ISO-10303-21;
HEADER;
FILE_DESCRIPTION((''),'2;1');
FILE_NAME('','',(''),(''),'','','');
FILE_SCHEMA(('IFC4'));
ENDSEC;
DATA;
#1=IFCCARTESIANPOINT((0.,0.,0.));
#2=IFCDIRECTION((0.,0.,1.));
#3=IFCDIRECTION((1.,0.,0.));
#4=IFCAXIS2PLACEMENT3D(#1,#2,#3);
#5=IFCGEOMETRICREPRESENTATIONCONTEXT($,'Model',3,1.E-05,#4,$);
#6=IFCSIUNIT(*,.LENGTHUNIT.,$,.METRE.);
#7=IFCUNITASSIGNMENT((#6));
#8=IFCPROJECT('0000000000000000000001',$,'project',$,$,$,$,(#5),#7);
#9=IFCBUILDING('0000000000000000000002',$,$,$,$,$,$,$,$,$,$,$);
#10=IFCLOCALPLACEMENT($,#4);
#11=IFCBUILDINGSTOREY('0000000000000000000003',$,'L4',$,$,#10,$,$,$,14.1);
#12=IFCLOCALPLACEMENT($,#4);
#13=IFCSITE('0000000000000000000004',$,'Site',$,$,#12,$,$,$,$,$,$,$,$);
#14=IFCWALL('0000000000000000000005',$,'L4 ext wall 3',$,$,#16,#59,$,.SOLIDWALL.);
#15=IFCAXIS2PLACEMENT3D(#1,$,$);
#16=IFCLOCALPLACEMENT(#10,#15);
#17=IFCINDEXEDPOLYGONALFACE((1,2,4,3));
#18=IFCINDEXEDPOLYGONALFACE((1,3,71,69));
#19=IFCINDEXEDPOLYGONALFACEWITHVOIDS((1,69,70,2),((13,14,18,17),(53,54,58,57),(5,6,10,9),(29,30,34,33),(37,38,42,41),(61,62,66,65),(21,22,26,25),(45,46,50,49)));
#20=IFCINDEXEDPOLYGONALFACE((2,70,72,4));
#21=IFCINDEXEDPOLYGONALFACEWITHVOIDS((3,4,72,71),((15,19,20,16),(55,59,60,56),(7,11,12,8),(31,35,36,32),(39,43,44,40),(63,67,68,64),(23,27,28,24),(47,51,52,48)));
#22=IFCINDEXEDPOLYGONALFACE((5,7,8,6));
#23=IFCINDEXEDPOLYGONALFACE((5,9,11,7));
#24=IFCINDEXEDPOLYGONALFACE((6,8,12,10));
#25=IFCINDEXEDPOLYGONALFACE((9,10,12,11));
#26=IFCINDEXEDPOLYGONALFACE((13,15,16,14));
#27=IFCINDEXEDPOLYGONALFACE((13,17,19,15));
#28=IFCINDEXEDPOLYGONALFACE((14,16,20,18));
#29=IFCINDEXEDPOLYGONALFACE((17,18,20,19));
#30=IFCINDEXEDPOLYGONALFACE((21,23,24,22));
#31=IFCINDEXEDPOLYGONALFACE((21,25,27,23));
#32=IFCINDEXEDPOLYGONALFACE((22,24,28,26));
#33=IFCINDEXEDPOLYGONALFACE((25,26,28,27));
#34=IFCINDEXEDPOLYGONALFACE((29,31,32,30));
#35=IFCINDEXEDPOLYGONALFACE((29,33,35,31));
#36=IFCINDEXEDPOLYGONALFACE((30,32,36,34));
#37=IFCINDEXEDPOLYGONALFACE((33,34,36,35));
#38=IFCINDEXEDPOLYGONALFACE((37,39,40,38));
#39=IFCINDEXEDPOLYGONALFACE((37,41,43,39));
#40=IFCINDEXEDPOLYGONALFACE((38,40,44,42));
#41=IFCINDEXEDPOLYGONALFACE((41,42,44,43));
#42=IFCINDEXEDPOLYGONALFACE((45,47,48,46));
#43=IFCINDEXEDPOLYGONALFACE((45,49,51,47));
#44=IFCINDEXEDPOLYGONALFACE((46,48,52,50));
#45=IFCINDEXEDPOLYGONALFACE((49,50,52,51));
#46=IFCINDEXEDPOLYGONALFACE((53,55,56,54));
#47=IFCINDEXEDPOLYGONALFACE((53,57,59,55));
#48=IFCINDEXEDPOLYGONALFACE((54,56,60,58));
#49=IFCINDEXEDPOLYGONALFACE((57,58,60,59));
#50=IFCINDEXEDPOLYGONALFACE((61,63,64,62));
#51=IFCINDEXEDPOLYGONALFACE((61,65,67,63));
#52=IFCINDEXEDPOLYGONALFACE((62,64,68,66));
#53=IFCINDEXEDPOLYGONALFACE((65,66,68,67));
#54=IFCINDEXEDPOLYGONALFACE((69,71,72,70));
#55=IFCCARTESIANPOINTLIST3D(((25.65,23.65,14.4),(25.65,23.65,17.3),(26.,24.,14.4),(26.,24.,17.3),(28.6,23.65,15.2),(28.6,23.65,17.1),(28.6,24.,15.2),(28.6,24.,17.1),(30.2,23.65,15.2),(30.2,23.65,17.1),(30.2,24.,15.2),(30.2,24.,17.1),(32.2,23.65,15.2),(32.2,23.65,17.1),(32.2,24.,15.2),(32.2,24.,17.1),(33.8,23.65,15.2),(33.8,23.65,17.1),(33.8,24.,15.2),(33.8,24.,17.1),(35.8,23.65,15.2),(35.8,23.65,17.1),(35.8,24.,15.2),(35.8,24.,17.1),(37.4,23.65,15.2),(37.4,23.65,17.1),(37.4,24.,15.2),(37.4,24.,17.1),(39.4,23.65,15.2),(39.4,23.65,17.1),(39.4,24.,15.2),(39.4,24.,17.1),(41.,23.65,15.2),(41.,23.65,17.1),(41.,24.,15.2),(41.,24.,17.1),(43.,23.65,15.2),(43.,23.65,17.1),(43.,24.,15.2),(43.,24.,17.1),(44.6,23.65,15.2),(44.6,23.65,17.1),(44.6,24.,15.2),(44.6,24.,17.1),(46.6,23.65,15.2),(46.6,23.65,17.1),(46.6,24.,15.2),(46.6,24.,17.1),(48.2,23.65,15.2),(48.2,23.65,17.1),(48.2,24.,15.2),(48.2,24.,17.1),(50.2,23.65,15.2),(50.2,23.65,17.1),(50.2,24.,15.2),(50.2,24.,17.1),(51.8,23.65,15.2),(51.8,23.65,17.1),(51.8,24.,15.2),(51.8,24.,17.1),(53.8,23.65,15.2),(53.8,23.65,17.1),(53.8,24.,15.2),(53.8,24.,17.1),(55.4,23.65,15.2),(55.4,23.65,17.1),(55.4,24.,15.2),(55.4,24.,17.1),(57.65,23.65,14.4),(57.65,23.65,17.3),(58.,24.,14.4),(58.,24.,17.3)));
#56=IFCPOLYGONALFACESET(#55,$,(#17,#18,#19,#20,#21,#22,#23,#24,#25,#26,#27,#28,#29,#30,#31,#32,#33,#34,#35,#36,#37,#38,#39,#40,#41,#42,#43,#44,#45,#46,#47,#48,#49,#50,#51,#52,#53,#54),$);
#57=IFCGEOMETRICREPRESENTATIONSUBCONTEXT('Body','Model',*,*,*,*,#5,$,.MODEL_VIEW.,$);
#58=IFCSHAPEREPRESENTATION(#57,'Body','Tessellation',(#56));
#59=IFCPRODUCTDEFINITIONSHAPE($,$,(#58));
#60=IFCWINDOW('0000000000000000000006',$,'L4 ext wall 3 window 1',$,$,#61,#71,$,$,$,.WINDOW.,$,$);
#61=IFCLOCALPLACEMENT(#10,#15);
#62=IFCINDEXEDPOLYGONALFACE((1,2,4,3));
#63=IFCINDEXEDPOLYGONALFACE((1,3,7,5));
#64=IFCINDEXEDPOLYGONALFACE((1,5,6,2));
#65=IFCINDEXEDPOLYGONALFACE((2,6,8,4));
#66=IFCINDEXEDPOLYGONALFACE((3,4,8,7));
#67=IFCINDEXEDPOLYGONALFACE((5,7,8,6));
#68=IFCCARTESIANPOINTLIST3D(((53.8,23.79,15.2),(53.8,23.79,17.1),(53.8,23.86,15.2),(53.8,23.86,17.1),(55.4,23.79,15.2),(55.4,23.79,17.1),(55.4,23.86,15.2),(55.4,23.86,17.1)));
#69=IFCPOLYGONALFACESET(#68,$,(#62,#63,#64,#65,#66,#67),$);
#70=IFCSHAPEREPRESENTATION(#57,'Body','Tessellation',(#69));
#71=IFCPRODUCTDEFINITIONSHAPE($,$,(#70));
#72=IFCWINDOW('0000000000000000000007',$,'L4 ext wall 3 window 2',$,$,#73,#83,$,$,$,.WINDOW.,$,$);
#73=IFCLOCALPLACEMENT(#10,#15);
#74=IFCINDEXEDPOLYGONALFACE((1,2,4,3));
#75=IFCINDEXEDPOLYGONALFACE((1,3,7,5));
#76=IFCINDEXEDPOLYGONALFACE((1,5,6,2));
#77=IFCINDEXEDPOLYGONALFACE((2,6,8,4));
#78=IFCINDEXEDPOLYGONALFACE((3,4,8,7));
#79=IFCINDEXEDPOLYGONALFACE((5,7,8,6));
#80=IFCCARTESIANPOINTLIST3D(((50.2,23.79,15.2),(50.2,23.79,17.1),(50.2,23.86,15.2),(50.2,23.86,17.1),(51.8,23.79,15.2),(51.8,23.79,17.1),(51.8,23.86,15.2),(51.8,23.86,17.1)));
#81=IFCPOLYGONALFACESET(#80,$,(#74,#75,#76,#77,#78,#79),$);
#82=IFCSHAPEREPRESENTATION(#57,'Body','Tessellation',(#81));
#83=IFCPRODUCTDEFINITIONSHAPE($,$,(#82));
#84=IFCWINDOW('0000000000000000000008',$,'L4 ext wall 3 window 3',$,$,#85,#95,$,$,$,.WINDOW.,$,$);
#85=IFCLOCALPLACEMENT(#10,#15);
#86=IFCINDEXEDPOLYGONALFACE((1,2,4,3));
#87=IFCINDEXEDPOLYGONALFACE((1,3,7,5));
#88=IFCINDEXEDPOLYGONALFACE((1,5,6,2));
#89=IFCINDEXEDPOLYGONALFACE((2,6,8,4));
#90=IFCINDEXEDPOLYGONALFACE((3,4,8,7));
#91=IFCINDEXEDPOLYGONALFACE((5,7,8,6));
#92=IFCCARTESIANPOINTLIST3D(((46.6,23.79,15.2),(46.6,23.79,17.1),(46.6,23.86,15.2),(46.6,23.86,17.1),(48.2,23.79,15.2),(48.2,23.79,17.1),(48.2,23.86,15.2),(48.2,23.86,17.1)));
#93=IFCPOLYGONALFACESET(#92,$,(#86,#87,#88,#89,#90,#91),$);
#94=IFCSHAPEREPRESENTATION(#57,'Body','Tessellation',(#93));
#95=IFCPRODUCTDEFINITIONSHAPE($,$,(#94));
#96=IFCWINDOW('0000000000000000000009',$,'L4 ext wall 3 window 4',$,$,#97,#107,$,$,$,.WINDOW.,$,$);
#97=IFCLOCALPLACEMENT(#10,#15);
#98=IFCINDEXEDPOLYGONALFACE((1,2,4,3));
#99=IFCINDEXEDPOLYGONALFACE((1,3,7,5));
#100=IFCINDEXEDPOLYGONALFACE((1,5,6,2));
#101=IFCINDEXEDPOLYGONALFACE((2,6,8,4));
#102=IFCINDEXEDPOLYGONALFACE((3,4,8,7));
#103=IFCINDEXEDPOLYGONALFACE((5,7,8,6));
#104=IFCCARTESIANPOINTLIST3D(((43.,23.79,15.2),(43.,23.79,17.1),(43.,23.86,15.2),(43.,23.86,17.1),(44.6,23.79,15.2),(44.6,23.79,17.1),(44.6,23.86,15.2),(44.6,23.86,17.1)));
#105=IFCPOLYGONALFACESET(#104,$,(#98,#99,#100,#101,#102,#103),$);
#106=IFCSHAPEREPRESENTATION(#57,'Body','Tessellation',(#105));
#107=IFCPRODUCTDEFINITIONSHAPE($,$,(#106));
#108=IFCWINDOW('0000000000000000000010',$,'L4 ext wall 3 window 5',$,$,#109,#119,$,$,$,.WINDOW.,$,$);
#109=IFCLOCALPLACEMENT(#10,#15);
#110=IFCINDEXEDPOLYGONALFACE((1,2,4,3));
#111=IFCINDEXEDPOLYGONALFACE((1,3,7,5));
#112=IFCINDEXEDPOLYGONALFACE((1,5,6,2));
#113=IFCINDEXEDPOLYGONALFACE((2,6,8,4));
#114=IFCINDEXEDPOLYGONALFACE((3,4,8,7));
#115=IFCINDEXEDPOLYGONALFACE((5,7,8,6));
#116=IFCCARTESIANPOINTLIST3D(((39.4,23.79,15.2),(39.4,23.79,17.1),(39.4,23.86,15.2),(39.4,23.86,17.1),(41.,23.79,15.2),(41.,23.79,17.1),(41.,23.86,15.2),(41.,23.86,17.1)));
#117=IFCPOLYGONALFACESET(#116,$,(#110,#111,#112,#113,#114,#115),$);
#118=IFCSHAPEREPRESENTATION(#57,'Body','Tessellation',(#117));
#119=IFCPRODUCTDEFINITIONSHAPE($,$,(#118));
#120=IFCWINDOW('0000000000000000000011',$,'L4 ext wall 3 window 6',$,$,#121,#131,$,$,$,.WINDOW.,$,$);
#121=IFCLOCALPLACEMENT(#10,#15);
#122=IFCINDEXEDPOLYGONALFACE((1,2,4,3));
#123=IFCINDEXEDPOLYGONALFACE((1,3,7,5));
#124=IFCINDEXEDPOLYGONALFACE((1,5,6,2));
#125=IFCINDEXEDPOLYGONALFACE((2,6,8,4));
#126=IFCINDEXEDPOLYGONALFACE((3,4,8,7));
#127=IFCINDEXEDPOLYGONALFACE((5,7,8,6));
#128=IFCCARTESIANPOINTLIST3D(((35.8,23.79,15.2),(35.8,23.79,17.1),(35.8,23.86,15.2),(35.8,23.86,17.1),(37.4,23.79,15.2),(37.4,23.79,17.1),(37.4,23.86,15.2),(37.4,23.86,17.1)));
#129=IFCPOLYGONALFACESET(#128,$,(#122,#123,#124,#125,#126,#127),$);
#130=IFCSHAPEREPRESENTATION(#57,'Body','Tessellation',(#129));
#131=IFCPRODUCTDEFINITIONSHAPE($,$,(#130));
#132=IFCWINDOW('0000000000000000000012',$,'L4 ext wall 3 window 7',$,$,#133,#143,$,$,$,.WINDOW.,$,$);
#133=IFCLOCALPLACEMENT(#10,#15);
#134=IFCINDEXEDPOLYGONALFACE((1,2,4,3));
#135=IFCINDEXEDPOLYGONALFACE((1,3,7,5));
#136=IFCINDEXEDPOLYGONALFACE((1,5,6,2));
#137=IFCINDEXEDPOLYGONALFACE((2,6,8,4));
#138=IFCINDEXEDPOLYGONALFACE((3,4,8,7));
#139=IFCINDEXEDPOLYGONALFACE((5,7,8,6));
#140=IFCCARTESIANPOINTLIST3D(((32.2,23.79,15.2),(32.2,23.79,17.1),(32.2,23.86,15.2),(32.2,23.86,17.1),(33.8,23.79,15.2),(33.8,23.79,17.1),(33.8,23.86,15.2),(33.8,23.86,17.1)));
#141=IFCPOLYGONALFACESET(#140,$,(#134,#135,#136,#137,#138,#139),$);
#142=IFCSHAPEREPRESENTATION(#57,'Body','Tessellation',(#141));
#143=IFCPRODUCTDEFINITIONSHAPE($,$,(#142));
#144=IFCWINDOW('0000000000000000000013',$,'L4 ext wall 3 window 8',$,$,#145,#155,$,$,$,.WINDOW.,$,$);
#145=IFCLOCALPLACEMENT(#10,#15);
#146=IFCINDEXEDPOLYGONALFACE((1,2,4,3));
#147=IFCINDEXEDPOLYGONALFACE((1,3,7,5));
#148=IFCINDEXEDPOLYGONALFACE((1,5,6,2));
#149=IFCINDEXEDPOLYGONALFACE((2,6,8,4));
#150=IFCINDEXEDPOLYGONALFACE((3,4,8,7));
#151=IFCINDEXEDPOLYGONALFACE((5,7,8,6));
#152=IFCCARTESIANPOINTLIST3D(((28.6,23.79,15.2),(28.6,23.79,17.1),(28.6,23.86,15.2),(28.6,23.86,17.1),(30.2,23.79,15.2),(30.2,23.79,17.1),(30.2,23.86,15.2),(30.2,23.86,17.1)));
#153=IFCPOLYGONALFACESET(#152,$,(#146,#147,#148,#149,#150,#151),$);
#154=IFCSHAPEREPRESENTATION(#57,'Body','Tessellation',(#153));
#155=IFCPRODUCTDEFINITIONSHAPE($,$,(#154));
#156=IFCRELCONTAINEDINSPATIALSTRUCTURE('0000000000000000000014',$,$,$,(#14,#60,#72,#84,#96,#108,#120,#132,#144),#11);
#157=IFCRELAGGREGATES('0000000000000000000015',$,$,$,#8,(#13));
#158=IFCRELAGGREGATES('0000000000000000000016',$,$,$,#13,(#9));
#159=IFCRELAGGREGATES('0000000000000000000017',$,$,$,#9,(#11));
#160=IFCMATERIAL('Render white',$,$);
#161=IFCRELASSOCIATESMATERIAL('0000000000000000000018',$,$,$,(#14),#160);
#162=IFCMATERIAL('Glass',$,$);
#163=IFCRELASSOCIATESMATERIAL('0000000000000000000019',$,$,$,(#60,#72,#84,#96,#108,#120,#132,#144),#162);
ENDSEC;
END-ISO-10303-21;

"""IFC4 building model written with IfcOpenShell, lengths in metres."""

from ifc_helpers import new_model, si_unit, frame, origin_with_axes, place, context, subcontext, project, spatial, polyline, outline, extrude, material, element, fill, save


model = new_model("IFC4")

# Units and contexts
model_context = context("Model", 3, precision=1e-05, world=origin_with_axes())
body_context = subcontext(model_context, "Body", "Model", "MODEL_VIEW")
ifc_project = project(units=[si_unit("LENGTHUNIT", "METRE")], contexts=[model_context])

# Site, building, storey
site_placement = place(None, origin_with_axes())
site = spatial("IfcSite", under=ifc_project, at=site_placement, Name="Site")
building = spatial("IfcBuilding", under=site)
storey_placement = place(None, origin_with_axes())
storey = spatial("IfcBuildingStorey", under=building, at=storey_placement, Name="L4", Elevation=14.1)

# Wall, openings, windows
ifc_material_1 = material(Name="Render white")
wall_1_placement = place(storey_placement, origin_with_axes())
wall_1 = element("IfcWall", 1, at=wall_1_placement, inside=storey, material=ifc_material_1, Name="L4 ext wall 3", PredefinedType="SOLIDWALL", context=body_context, shape_type="SweptSolid", body=[
    extrude(outline(polyline([(58.0, 24.0), (26.0, 24.0), (25.65, 23.65), (57.65, 23.65), (58.0, 24.0)])), frame((0.0, 0.0, 14.4), z_axis=(0.0, 0.0, 1.0), x_axis=(1.0, 0.0, 0.0)), (0.0, 0.0, 1.0), 2.9),
])
opening_1_placement = place(wall_1_placement, origin_with_axes())
opening_1 = element("IfcOpeningElement", 2, at=opening_1_placement, cuts=wall_1, context=body_context, shape_type="SweptSolid", body=[
    extrude(outline(polyline([(55.4, 24.05), (53.8, 24.05), (53.8, 23.6), (55.4, 23.6), (55.4, 24.05)])), frame((0.0, 0.0, 15.2), z_axis=(0.0, 0.0, 1.0), x_axis=(1.0, 0.0, 0.0)), (0.0, 0.0, 1.0), 1.9),
])
opening_2_placement = place(wall_1_placement, origin_with_axes())
opening_2 = element("IfcOpeningElement", 3, at=opening_2_placement, cuts=wall_1, context=body_context, shape_type="SweptSolid", body=[
    extrude(outline(polyline([(51.8, 24.05), (50.2, 24.05), (50.2, 23.6), (51.8, 23.6), (51.8, 24.05)])), frame((0.0, 0.0, 15.2), z_axis=(0.0, 0.0, 1.0), x_axis=(1.0, 0.0, 0.0)), (0.0, 0.0, 1.0), 1.9),
])
opening_3_placement = place(wall_1_placement, origin_with_axes())
opening_3 = element("IfcOpeningElement", 4, at=opening_3_placement, cuts=wall_1, context=body_context, shape_type="SweptSolid", body=[
    extrude(outline(polyline([(48.2, 24.05), (46.6, 24.05), (46.6, 23.6), (48.2, 23.6), (48.2, 24.05)])), frame((0.0, 0.0, 15.2), z_axis=(0.0, 0.0, 1.0), x_axis=(1.0, 0.0, 0.0)), (0.0, 0.0, 1.0), 1.9),
])
opening_4_placement = place(wall_1_placement, origin_with_axes())
opening_4 = element("IfcOpeningElement", 5, at=opening_4_placement, cuts=wall_1, context=body_context, shape_type="SweptSolid", body=[
    extrude(outline(polyline([(44.6, 24.05), (43.0, 24.05), (43.0, 23.6), (44.6, 23.6), (44.6, 24.05)])), frame((0.0, 0.0, 15.2), z_axis=(0.0, 0.0, 1.0), x_axis=(1.0, 0.0, 0.0)), (0.0, 0.0, 1.0), 1.9),
])
opening_5_placement = place(wall_1_placement, origin_with_axes())
opening_5 = element("IfcOpeningElement", 6, at=opening_5_placement, cuts=wall_1, context=body_context, shape_type="SweptSolid", body=[
    extrude(outline(polyline([(41.0, 24.05), (39.4, 24.05), (39.4, 23.6), (41.0, 23.6), (41.0, 24.05)])), frame((0.0, 0.0, 15.2), z_axis=(0.0, 0.0, 1.0), x_axis=(1.0, 0.0, 0.0)), (0.0, 0.0, 1.0), 1.9),
])
opening_6_placement = place(wall_1_placement, origin_with_axes())
opening_6 = element("IfcOpeningElement", 7, at=opening_6_placement, cuts=wall_1, context=body_context, shape_type="SweptSolid", body=[
    extrude(outline(polyline([(37.4, 24.05), (35.8, 24.05), (35.8, 23.6), (37.4, 23.6), (37.4, 24.05)])), frame((0.0, 0.0, 15.2), z_axis=(0.0, 0.0, 1.0), x_axis=(1.0, 0.0, 0.0)), (0.0, 0.0, 1.0), 1.9),
])
opening_7_placement = place(wall_1_placement, origin_with_axes())
opening_7 = element("IfcOpeningElement", 8, at=opening_7_placement, cuts=wall_1, context=body_context, shape_type="SweptSolid", body=[
    extrude(outline(polyline([(33.8, 24.05), (32.2, 24.05), (32.2, 23.6), (33.8, 23.6), (33.8, 24.05)])), frame((0.0, 0.0, 15.2), z_axis=(0.0, 0.0, 1.0), x_axis=(1.0, 0.0, 0.0)), (0.0, 0.0, 1.0), 1.9),
])
opening_8_placement = place(wall_1_placement, origin_with_axes())
opening_8 = element("IfcOpeningElement", 9, at=opening_8_placement, cuts=wall_1, context=body_context, shape_type="SweptSolid", body=[
    extrude(outline(polyline([(30.2, 24.05), (28.6, 24.05), (28.6, 23.6), (30.2, 23.6), (30.2, 24.05)])), frame((0.0, 0.0, 15.2), z_axis=(0.0, 0.0, 1.0), x_axis=(1.0, 0.0, 0.0)), (0.0, 0.0, 1.0), 1.9),
])
ifc_material_2 = material(Name="Glass")
window_1_placement = place(storey_placement, origin_with_axes())
window_1 = element("IfcWindow", 10, at=window_1_placement, inside=storey, material=ifc_material_2, Name="L4 ext wall 3 window 1", PredefinedType="WINDOW", context=body_context, shape_type="SweptSolid", body=[
    extrude(outline(polyline([(55.4, 23.86), (53.8, 23.86), (53.8, 23.79), (55.4, 23.79), (55.4, 23.86)])), frame((0.0, 0.0, 15.2), z_axis=(0.0, 0.0, 1.0), x_axis=(1.0, 0.0, 0.0)), (0.0, 0.0, 1.0), 1.9),
])
fill(opening_1, window_1)
window_2_placement = place(storey_placement, origin_with_axes())
window_2 = element("IfcWindow", 11, at=window_2_placement, inside=storey, material=ifc_material_2, Name="L4 ext wall 3 window 2", PredefinedType="WINDOW", context=body_context, shape_type="SweptSolid", body=[
    extrude(outline(polyline([(51.8, 23.86), (50.2, 23.86), (50.2, 23.79), (51.8, 23.79), (51.8, 23.86)])), frame((0.0, 0.0, 15.2), z_axis=(0.0, 0.0, 1.0), x_axis=(1.0, 0.0, 0.0)), (0.0, 0.0, 1.0), 1.9),
])
fill(opening_2, window_2)
window_3_placement = place(storey_placement, origin_with_axes())
window_3 = element("IfcWindow", 12, at=window_3_placement, inside=storey, material=ifc_material_2, Name="L4 ext wall 3 window 3", PredefinedType="WINDOW", context=body_context, shape_type="SweptSolid", body=[
    extrude(outline(polyline([(48.2, 23.86), (46.6, 23.86), (46.6, 23.79), (48.2, 23.79), (48.2, 23.86)])), frame((0.0, 0.0, 15.2), z_axis=(0.0, 0.0, 1.0), x_axis=(1.0, 0.0, 0.0)), (0.0, 0.0, 1.0), 1.9),
])
fill(opening_3, window_3)
window_4_placement = place(storey_placement, origin_with_axes())
window_4 = element("IfcWindow", 13, at=window_4_placement, inside=storey, material=ifc_material_2, Name="L4 ext wall 3 window 4", PredefinedType="WINDOW", context=body_context, shape_type="SweptSolid", body=[
    extrude(outline(polyline([(44.6, 23.86), (43.0, 23.86), (43.0, 23.79), (44.6, 23.79), (44.6, 23.86)])), frame((0.0, 0.0, 15.2), z_axis=(0.0, 0.0, 1.0), x_axis=(1.0, 0.0, 0.0)), (0.0, 0.0, 1.0), 1.9),
])
fill(opening_4, window_4)
window_5_placement = place(storey_placement, origin_with_axes())
window_5 = element("IfcWindow", 14, at=window_5_placement, inside=storey, material=ifc_material_2, Name="L4 ext wall 3 window 5", PredefinedType="WINDOW", context=body_context, shape_type="SweptSolid", body=[
    extrude(outline(polyline([(41.0, 23.86), (39.4, 23.86), (39.4, 23.79), (41.0, 23.79), (41.0, 23.86)])), frame((0.0, 0.0, 15.2), z_axis=(0.0, 0.0, 1.0), x_axis=(1.0, 0.0, 0.0)), (0.0, 0.0, 1.0), 1.9),
])
fill(opening_5, window_5)
window_6_placement = place(storey_placement, origin_with_axes())
window_6 = element("IfcWindow", 15, at=window_6_placement, inside=storey, material=ifc_material_2, Name="L4 ext wall 3 window 6", PredefinedType="WINDOW", context=body_context, shape_type="SweptSolid", body=[
    extrude(outline(polyline([(37.4, 23.86), (35.8, 23.86), (35.8, 23.79), (37.4, 23.79), (37.4, 23.86)])), frame((0.0, 0.0, 15.2), z_axis=(0.0, 0.0, 1.0), x_axis=(1.0, 0.0, 0.0)), (0.0, 0.0, 1.0), 1.9),
])
fill(opening_6, window_6)
window_7_placement = place(storey_placement, origin_with_axes())
window_7 = element("IfcWindow", 16, at=window_7_placement, inside=storey, material=ifc_material_2, Name="L4 ext wall 3 window 7", PredefinedType="WINDOW", context=body_context, shape_type="SweptSolid", body=[
    extrude(outline(polyline([(33.8, 23.86), (32.2, 23.86), (32.2, 23.79), (33.8, 23.79), (33.8, 23.86)])), frame((0.0, 0.0, 15.2), z_axis=(0.0, 0.0, 1.0), x_axis=(1.0, 0.0, 0.0)), (0.0, 0.0, 1.0), 1.9),
])
fill(opening_7, window_7)
window_8_placement = place(storey_placement, origin_with_axes())
window_8 = element("IfcWindow", 17, at=window_8_placement, inside=storey, material=ifc_material_2, Name="L4 ext wall 3 window 8", PredefinedType="WINDOW", context=body_context, shape_type="SweptSolid", body=[
    extrude(outline(polyline([(30.2, 23.86), (28.6, 23.86), (28.6, 23.79), (30.2, 23.79), (30.2, 23.86)])), frame((0.0, 0.0, 15.2), z_axis=(0.0, 0.0, 1.0), x_axis=(1.0, 0.0, 0.0)), (0.0, 0.0, 1.0), 1.9),
])
fill(opening_8, window_8)

save(model, "model.ifc")
